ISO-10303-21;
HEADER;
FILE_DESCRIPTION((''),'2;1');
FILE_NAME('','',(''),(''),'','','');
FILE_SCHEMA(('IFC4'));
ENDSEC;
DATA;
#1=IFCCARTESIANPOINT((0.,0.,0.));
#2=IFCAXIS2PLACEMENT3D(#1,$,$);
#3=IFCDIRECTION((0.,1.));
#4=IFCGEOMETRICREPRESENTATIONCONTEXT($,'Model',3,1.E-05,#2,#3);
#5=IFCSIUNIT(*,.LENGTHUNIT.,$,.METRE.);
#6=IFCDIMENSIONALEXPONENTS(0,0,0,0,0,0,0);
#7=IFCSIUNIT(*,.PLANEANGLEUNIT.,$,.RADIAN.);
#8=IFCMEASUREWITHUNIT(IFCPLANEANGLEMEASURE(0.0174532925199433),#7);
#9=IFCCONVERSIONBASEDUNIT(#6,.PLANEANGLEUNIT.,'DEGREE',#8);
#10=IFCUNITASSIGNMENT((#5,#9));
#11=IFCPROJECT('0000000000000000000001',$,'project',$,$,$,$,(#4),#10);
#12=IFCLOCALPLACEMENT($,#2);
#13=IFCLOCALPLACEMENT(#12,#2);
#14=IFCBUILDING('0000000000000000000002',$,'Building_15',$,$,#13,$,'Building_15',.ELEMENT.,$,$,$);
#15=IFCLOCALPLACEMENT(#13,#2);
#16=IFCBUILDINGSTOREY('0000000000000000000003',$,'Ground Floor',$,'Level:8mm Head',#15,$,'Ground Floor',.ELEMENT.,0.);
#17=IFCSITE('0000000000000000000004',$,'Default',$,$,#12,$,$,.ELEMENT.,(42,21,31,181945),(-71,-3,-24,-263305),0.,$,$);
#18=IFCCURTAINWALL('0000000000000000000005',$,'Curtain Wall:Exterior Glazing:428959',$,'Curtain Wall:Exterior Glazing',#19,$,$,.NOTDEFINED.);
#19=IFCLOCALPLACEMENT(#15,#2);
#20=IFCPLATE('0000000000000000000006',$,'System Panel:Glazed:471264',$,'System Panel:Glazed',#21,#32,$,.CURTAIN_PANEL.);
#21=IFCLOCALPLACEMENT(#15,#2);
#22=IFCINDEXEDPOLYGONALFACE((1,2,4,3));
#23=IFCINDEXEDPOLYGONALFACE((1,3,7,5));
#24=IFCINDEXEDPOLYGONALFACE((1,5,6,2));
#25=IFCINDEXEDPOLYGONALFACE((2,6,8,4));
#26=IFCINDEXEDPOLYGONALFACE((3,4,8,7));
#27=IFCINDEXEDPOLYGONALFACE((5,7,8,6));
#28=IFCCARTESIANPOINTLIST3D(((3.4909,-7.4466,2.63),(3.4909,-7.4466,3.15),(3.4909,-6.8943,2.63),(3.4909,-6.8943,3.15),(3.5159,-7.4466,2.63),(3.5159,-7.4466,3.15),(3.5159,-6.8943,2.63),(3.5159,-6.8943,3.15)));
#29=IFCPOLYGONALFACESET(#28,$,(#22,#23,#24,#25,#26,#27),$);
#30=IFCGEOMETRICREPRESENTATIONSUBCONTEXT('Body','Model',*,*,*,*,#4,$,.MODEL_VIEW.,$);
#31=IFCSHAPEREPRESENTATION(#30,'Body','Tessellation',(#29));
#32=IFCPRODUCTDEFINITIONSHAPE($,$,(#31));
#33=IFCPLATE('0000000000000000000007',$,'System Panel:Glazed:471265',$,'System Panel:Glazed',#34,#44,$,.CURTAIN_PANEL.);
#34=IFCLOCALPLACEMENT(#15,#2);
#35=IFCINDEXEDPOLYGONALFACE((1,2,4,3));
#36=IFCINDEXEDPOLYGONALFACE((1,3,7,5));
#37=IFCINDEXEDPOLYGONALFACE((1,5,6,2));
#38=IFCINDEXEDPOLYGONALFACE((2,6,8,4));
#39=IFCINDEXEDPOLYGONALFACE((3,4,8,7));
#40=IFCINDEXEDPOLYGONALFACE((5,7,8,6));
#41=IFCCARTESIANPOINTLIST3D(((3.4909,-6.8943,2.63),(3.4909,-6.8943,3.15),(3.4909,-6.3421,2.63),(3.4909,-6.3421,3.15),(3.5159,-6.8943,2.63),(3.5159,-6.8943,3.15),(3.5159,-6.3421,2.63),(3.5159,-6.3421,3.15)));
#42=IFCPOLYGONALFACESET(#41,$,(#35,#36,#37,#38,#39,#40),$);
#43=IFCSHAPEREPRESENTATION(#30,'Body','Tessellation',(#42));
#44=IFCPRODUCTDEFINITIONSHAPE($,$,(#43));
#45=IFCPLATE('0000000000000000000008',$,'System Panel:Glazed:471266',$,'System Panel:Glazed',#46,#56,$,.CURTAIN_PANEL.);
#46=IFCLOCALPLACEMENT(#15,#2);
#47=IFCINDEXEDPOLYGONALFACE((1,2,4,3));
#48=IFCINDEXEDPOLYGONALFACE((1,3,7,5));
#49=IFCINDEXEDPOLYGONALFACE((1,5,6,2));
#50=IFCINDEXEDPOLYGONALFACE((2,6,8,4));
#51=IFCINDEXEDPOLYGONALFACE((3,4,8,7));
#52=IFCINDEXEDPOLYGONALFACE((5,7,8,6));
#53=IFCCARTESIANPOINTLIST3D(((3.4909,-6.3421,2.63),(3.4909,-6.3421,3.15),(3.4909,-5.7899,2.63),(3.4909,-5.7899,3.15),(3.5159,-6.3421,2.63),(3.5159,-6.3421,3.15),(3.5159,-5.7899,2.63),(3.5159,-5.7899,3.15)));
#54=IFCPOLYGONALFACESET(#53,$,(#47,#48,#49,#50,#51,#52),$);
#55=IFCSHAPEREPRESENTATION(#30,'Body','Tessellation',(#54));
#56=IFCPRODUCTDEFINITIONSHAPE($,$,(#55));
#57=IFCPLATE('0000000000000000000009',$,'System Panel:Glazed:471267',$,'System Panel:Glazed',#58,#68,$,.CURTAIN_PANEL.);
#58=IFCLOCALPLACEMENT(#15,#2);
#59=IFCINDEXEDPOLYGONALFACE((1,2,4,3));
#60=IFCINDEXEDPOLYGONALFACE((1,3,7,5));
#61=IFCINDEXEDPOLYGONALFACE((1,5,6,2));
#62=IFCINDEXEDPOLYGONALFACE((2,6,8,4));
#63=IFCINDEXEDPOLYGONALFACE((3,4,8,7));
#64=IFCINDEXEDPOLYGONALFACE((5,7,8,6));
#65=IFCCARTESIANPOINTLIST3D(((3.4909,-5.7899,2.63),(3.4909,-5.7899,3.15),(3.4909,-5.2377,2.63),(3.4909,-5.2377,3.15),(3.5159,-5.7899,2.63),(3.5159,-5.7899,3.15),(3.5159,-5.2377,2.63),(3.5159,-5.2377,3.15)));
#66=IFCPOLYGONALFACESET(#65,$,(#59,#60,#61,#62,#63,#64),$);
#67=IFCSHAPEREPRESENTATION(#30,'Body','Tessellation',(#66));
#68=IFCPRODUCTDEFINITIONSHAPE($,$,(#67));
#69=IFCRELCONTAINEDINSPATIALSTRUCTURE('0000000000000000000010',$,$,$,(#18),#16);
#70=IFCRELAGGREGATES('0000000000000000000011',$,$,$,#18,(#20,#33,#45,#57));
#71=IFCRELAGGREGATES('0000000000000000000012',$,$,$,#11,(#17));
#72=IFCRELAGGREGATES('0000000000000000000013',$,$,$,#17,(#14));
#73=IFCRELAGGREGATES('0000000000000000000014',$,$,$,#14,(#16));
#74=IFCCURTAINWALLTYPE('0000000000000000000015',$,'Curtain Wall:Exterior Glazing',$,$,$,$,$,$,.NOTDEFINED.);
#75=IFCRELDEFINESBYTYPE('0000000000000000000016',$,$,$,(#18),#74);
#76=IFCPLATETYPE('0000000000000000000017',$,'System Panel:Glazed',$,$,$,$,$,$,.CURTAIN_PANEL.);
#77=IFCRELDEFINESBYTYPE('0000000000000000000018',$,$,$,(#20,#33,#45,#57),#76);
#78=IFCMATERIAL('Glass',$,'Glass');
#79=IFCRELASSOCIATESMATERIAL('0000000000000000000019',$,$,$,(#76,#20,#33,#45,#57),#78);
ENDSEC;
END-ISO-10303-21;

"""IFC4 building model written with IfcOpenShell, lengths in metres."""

from ifc_helpers import new_model, entity, si_unit, converted_unit, direction, frame, origin, place, context, subcontext, project, spatial, indexed_curve, outline, extrude, source, transform, mapped, material, type_object, type_shapes, element, aggregate, save


model = new_model("IFC4")

# Units and contexts
model_context = context("Model", 3, precision=1e-05, world=origin(), true_north=direction((0.0, 1.0)))
body_context = subcontext(model_context, "Body", "Model", "MODEL_VIEW")
ifc_project = project(units=[si_unit("LENGTHUNIT", "METRE"), converted_unit("PLANEANGLEUNIT", "DEGREE", entity("IfcPlaneAngleMeasure", 0.0174532925199433), si_unit("PLANEANGLEUNIT", "RADIAN"), dimensions=[0, 0, 0, 0, 0, 0, 0])], contexts=[model_context])

# Site, building, storey
site_placement = place(None, origin())
site = spatial("IfcSite", under=ifc_project, at=site_placement, Name="Default", CompositionType="ELEMENT", RefLatitude=(42, 21, 31, 181945), RefLongitude=(-71, -3, -24, -263305), RefElevation=0.0)
building_placement = place(site_placement, origin())
building = spatial("IfcBuilding", under=site, at=building_placement, Name="Building_15", LongName="Building_15", CompositionType="ELEMENT")
storey_placement = place(building_placement, origin())
storey = spatial("IfcBuildingStorey", under=building, at=storey_placement, Name="Ground Floor", ObjectType="Level:8mm Head", LongName="Ground Floor", CompositionType="ELEMENT", Elevation=0.0)

# Curtain wall, plates
curtain_wall_type = type_object("IfcCurtainWallType", Name="Curtain Wall:Exterior Glazing", PredefinedType="NOTDEFINED")
curtain_wall_placement = place(storey_placement, origin())
curtain_wall = element("IfcCurtainWall", 1, at=curtain_wall_placement, inside=storey, type_object=curtain_wall_type, Name="Curtain Wall:Exterior Glazing:428959", ObjectType="Curtain Wall:Exterior Glazing", PredefinedType="NOTDEFINED")
ifc_material_1 = material(Name="Glass", Category="Glass")
plate_type_1 = type_object("IfcPlateType", Name="System Panel:Glazed", PredefinedType="CURTAIN_PANEL", material=ifc_material_1)
shared_shape_1 = source(origin(), body_context, "Body", "SweptSolid", [
    extrude(outline(indexed_curve([(-0.0125, -0.2761), (0.0125, -0.2761), (0.0125, 0.2761), (-0.0125, 0.2761), (-0.0125, -0.2761)], self_intersect=False)), frame((0.0, 0.037, 0.0), z_axis=(0.0, 0.0, 1.0), x_axis=(0.0, 1.0, 0.0)), (0.0, 0.0, 1.0), 0.52),
])
type_shapes(plate_type_1, [shared_shape_1])
plate_1_placement = place(curtain_wall_placement, frame((3.5404, -7.1705, 2.63), z_axis=(0.0, 0.0, 1.0), x_axis=(0.0, 1.0, 0.0)))
plate_1 = element("IfcPlate", 2, at=plate_1_placement, type_object=plate_type_1, material=ifc_material_1, Name="System Panel:Glazed:471264", ObjectType="System Panel:Glazed", PredefinedType="CURTAIN_PANEL", context=body_context, shape_type="MappedRepresentation", body=[
    mapped(shared_shape_1, transform((0.0, 0.0, 0.0), scale=1.0)),
])
plate_2_placement = place(curtain_wall_placement, frame((3.5404, -6.6182, 2.63), z_axis=(0.0, 0.0, 1.0), x_axis=(0.0, 1.0, 0.0)))
plate_2 = element("IfcPlate", 3, at=plate_2_placement, type_object=plate_type_1, material=ifc_material_1, Name="System Panel:Glazed:471265", ObjectType="System Panel:Glazed", PredefinedType="CURTAIN_PANEL", context=body_context, shape_type="MappedRepresentation", body=[
    mapped(shared_shape_1, transform((0.0, 0.0, 0.0), scale=1.0)),
])
plate_3_placement = place(curtain_wall_placement, frame((3.5404, -6.066, 2.63), z_axis=(0.0, 0.0, 1.0), x_axis=(0.0, 1.0, 0.0)))
plate_3 = element("IfcPlate", 4, at=plate_3_placement, type_object=plate_type_1, material=ifc_material_1, Name="System Panel:Glazed:471266", ObjectType="System Panel:Glazed", PredefinedType="CURTAIN_PANEL", context=body_context, shape_type="MappedRepresentation", body=[
    mapped(shared_shape_1, transform((0.0, 0.0, 0.0), scale=1.0)),
])
plate_4_placement = place(curtain_wall_placement, frame((3.5404, -5.5138, 2.63), z_axis=(0.0, 0.0, 1.0), x_axis=(0.0, 1.0, 0.0)))
plate_4 = element("IfcPlate", 5, at=plate_4_placement, type_object=plate_type_1, material=ifc_material_1, Name="System Panel:Glazed:471267", ObjectType="System Panel:Glazed", PredefinedType="CURTAIN_PANEL", context=body_context, shape_type="MappedRepresentation", body=[
    mapped(shared_shape_1, transform((0.0, 0.0, 0.0), scale=1.0)),
])
aggregate(curtain_wall, [plate_1, plate_2, plate_3, plate_4])

save(model, "model.ifc")
